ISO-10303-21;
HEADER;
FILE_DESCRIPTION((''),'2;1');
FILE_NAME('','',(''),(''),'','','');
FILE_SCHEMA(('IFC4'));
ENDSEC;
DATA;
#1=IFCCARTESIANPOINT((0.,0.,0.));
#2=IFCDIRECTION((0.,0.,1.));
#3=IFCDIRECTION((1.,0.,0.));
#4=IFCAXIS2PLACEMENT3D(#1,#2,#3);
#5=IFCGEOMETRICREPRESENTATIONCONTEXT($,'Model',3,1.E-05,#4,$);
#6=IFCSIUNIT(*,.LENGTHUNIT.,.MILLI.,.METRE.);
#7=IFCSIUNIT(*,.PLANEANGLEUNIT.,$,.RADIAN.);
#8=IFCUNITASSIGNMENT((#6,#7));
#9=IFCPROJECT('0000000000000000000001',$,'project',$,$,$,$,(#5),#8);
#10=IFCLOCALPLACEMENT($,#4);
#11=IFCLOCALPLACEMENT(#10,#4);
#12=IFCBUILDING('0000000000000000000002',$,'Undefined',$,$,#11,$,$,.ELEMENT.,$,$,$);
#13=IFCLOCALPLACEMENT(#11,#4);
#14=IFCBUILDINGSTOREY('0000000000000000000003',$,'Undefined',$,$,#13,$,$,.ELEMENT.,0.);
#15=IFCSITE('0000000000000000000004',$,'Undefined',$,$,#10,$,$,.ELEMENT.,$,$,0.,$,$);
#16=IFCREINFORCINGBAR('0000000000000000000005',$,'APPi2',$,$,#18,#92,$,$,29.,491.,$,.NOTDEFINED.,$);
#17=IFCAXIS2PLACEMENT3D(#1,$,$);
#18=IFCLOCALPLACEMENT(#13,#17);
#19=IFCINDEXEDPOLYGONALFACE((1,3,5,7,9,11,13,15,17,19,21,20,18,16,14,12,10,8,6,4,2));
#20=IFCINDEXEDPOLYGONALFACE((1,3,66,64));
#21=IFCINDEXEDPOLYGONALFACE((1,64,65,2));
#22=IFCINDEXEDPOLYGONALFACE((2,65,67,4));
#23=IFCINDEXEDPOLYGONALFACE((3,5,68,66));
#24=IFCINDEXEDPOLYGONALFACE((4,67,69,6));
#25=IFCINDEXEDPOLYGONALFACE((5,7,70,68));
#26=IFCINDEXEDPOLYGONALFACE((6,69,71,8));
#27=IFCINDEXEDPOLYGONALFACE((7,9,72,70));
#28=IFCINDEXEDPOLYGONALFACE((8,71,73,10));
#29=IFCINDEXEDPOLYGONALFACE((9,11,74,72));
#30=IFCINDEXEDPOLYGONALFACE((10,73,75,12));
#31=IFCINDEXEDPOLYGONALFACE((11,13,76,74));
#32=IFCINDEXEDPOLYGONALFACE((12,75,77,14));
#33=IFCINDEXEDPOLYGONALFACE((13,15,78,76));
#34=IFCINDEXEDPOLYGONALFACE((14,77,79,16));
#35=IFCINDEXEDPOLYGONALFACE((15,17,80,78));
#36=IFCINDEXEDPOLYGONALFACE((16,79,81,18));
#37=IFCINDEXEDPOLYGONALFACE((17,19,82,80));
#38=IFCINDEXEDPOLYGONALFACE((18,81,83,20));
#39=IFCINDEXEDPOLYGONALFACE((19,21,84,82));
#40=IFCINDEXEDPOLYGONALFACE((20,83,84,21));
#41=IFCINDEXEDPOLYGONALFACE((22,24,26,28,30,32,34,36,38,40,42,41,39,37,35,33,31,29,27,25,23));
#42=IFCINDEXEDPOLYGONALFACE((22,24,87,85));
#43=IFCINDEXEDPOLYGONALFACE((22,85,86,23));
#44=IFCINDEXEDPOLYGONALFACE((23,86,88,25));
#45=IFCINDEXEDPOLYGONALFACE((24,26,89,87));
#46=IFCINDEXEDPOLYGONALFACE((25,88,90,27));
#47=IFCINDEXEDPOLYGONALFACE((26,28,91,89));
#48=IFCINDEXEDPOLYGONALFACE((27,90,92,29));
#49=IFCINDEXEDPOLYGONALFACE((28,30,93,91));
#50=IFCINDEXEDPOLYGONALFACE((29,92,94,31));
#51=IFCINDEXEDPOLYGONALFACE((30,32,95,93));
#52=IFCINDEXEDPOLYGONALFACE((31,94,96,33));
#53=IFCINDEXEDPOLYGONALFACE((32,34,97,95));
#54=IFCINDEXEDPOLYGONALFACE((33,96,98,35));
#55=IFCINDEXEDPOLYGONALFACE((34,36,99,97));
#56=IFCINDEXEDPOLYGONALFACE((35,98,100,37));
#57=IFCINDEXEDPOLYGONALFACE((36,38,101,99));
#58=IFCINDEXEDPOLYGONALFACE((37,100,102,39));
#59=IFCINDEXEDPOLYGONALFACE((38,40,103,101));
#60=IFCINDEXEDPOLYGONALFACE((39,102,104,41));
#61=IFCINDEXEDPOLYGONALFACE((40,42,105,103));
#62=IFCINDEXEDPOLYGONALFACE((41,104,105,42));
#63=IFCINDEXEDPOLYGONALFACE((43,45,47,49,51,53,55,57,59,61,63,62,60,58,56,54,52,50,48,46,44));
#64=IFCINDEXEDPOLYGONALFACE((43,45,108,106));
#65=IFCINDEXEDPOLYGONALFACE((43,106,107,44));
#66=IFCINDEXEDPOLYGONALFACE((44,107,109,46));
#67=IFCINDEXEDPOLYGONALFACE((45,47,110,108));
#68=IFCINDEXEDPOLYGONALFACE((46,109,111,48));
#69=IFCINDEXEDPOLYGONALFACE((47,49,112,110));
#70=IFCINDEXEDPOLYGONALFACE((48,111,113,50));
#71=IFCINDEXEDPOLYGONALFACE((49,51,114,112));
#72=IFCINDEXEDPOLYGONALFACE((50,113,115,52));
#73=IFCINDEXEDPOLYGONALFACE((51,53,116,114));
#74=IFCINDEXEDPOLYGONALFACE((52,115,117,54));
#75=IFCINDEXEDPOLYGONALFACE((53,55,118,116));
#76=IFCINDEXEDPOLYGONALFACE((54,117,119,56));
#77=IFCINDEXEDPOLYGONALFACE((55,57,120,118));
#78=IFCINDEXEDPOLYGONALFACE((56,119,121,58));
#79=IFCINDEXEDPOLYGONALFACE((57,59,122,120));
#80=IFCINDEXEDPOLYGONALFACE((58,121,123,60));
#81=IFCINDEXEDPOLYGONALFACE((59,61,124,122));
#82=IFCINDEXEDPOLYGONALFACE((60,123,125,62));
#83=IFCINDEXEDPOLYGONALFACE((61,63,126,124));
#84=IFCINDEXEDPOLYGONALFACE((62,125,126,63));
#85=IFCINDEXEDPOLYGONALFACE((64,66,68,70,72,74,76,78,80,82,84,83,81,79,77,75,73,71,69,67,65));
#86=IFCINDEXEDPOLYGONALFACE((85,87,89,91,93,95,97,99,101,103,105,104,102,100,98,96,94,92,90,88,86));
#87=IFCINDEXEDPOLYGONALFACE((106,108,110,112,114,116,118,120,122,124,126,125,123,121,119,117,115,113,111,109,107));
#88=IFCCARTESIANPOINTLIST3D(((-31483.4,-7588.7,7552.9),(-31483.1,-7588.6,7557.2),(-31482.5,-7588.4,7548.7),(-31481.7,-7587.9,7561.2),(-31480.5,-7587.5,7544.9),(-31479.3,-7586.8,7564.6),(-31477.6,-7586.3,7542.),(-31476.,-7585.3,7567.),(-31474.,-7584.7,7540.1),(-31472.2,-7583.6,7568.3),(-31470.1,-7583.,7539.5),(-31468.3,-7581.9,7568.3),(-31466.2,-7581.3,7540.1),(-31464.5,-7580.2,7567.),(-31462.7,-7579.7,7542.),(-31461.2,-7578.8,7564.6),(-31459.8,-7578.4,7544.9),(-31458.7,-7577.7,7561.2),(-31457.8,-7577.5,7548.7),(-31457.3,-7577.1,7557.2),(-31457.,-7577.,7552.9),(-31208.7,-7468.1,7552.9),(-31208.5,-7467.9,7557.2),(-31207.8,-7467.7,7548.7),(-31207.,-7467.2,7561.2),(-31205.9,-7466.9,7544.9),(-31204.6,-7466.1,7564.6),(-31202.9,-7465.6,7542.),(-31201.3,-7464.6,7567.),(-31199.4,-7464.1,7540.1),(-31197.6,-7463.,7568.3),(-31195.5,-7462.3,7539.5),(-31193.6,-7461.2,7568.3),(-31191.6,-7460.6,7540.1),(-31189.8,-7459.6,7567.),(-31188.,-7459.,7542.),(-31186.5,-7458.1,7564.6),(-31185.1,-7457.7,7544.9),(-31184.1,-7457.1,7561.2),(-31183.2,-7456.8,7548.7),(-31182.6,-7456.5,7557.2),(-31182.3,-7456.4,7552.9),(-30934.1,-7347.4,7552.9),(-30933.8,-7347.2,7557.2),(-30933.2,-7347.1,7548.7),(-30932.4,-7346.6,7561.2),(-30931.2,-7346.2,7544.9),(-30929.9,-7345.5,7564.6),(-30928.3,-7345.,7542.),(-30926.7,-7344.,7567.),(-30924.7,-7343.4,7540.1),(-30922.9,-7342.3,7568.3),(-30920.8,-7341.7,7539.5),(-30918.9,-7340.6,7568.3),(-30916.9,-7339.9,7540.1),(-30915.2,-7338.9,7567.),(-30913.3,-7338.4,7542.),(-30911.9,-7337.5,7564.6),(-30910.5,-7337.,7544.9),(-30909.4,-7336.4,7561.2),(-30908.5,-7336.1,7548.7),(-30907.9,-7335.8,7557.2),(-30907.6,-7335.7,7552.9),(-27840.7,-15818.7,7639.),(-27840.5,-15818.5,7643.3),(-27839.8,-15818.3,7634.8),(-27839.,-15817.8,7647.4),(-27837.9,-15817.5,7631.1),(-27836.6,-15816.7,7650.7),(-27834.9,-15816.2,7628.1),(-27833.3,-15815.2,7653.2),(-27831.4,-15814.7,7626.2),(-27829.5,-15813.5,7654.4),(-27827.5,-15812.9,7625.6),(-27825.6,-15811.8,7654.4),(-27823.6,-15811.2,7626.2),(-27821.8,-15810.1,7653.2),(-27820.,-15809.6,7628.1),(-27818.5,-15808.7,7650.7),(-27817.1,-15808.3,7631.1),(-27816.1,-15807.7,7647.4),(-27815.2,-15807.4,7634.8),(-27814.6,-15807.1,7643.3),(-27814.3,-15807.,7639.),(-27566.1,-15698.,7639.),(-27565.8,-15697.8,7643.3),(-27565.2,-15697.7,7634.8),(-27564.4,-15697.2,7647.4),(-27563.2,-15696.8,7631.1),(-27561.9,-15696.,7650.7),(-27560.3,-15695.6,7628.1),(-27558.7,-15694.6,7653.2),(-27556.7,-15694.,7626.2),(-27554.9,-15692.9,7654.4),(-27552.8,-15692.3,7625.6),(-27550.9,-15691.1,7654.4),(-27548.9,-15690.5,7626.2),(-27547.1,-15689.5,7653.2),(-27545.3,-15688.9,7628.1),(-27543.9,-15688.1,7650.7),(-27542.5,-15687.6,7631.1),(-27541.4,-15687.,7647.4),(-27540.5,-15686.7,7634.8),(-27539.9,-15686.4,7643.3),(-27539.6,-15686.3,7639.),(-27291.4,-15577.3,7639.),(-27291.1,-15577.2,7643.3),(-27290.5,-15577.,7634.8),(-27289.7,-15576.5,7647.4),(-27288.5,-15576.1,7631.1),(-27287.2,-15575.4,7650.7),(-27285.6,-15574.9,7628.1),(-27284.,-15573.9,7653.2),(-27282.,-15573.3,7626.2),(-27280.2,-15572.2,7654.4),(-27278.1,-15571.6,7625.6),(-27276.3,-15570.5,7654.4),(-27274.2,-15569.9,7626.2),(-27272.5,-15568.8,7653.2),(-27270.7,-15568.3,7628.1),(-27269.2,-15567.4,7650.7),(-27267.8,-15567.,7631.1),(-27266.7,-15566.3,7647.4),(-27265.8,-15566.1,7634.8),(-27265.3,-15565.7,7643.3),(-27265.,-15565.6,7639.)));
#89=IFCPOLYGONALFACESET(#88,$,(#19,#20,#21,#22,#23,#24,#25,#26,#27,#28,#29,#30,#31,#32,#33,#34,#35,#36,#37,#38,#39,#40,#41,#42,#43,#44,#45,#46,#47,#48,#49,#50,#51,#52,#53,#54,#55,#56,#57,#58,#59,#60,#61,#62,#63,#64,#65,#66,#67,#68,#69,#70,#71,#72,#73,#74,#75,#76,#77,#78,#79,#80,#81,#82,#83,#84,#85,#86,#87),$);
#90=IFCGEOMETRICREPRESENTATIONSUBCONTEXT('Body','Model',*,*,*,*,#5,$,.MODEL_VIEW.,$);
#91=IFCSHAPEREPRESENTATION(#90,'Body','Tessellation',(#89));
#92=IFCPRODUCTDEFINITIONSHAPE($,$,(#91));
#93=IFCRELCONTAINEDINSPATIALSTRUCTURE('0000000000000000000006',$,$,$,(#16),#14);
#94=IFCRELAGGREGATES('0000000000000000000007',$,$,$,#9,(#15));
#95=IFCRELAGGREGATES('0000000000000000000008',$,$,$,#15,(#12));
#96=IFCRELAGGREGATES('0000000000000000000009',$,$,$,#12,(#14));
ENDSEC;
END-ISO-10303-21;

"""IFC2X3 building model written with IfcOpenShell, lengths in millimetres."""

from ifc_helpers import new_model, entity, si_unit, frame, origin_with_axes, place, context, subcontext, project, spatial, source, transform, mapped, element, save


model = new_model("IFC2X3")

# Units and contexts
model_context = context("Model", 3, precision=1e-05, world=origin_with_axes())
body_context = subcontext(model_context, "Body", "Model", "MODEL_VIEW")
ifc_project = project(units=[si_unit("LENGTHUNIT", "METRE", prefix="MILLI"), si_unit("PLANEANGLEUNIT", "RADIAN")], contexts=[model_context])

# Site, building, storey
site_placement = place(None, origin_with_axes())
site = spatial("IfcSite", under=ifc_project, at=site_placement, Name="Undefined", CompositionType="ELEMENT", RefElevation=0.0)
building_placement = place(site_placement, origin_with_axes())
building = spatial("IfcBuilding", under=site, at=building_placement, Name="Undefined", CompositionType="ELEMENT")
storey_placement = place(building_placement, origin_with_axes())
storey = spatial("IfcBuildingStorey", under=building, at=storey_placement, Name="Undefined", CompositionType="ELEMENT", Elevation=0.0)

# Reinforcing bar
shared_shape_1 = source(origin_with_axes(), body_context, "Body", "AdvancedSweptSolid", [
    entity("IfcSweptDiskSolid", entity("IfcTrimmedCurve", entity("IfcLine", entity("IfcCartesianPoint", [0.0, 0.0, 0.0]), entity("IfcVector", entity("IfcDirection", [1.0, 0.0, 0.0]), 1.0)), [entity("IfcParameterValue", 0.0)], [entity("IfcParameterValue", 9000.45365)], True, "PARAMETER"), 14.5, None, 0.0, 9000.5),
])
shared_shape_2 = source(origin_with_axes(), body_context, "Body", "AdvancedSweptSolid", [
    entity("IfcSweptDiskSolid", entity("IfcTrimmedCurve", entity("IfcLine", entity("IfcCartesianPoint", [0.0, 0.0, 0.0]), entity("IfcVector", entity("IfcDirection", [1.0, 0.0, 0.0]), 1.0)), [entity("IfcParameterValue", 0.0)], [entity("IfcParameterValue", 9000.45365)], True, "PARAMETER"), 14.5, None, 0.0, 9000.5),
])
shared_shape_3 = source(origin_with_axes(), body_context, "Body", "AdvancedSweptSolid", [
    entity("IfcSweptDiskSolid", entity("IfcTrimmedCurve", entity("IfcLine", entity("IfcCartesianPoint", [0.0, 0.0, 0.0]), entity("IfcVector", entity("IfcDirection", [1.0, 0.0, 0.0]), 1.0)), [entity("IfcParameterValue", 0.0)], [entity("IfcParameterValue", 9000.45365)], True, "PARAMETER"), 14.5, None, 0.0, 9000.5),
])
reinforcing_bar_1_placement = place(storey_placement, frame((-30920.9, -7341.6, 7554.0), z_axis=(0.003848, -0.008761, -0.999954), x_axis=(0.404721, -0.91439, 0.009569)))
element("IfcReinforcingBar", 1, at=reinforcing_bar_1_placement, inside=storey, Name="APPi2", BarRole="NOTDEFINED", CrossSectionArea=491.0, NominalDiameter=29.0, context=body_context, shape_type="MappedRepresentation", body=[
    mapped(shared_shape_1, transform((0.0, 0.0, 0.0))),
    mapped(shared_shape_2, transform((-0.8, 300.0, 0.0))),
    mapped(shared_shape_3, transform((-1.7, 600.0, 0.0))),
])

save(model, "model.ifc")
